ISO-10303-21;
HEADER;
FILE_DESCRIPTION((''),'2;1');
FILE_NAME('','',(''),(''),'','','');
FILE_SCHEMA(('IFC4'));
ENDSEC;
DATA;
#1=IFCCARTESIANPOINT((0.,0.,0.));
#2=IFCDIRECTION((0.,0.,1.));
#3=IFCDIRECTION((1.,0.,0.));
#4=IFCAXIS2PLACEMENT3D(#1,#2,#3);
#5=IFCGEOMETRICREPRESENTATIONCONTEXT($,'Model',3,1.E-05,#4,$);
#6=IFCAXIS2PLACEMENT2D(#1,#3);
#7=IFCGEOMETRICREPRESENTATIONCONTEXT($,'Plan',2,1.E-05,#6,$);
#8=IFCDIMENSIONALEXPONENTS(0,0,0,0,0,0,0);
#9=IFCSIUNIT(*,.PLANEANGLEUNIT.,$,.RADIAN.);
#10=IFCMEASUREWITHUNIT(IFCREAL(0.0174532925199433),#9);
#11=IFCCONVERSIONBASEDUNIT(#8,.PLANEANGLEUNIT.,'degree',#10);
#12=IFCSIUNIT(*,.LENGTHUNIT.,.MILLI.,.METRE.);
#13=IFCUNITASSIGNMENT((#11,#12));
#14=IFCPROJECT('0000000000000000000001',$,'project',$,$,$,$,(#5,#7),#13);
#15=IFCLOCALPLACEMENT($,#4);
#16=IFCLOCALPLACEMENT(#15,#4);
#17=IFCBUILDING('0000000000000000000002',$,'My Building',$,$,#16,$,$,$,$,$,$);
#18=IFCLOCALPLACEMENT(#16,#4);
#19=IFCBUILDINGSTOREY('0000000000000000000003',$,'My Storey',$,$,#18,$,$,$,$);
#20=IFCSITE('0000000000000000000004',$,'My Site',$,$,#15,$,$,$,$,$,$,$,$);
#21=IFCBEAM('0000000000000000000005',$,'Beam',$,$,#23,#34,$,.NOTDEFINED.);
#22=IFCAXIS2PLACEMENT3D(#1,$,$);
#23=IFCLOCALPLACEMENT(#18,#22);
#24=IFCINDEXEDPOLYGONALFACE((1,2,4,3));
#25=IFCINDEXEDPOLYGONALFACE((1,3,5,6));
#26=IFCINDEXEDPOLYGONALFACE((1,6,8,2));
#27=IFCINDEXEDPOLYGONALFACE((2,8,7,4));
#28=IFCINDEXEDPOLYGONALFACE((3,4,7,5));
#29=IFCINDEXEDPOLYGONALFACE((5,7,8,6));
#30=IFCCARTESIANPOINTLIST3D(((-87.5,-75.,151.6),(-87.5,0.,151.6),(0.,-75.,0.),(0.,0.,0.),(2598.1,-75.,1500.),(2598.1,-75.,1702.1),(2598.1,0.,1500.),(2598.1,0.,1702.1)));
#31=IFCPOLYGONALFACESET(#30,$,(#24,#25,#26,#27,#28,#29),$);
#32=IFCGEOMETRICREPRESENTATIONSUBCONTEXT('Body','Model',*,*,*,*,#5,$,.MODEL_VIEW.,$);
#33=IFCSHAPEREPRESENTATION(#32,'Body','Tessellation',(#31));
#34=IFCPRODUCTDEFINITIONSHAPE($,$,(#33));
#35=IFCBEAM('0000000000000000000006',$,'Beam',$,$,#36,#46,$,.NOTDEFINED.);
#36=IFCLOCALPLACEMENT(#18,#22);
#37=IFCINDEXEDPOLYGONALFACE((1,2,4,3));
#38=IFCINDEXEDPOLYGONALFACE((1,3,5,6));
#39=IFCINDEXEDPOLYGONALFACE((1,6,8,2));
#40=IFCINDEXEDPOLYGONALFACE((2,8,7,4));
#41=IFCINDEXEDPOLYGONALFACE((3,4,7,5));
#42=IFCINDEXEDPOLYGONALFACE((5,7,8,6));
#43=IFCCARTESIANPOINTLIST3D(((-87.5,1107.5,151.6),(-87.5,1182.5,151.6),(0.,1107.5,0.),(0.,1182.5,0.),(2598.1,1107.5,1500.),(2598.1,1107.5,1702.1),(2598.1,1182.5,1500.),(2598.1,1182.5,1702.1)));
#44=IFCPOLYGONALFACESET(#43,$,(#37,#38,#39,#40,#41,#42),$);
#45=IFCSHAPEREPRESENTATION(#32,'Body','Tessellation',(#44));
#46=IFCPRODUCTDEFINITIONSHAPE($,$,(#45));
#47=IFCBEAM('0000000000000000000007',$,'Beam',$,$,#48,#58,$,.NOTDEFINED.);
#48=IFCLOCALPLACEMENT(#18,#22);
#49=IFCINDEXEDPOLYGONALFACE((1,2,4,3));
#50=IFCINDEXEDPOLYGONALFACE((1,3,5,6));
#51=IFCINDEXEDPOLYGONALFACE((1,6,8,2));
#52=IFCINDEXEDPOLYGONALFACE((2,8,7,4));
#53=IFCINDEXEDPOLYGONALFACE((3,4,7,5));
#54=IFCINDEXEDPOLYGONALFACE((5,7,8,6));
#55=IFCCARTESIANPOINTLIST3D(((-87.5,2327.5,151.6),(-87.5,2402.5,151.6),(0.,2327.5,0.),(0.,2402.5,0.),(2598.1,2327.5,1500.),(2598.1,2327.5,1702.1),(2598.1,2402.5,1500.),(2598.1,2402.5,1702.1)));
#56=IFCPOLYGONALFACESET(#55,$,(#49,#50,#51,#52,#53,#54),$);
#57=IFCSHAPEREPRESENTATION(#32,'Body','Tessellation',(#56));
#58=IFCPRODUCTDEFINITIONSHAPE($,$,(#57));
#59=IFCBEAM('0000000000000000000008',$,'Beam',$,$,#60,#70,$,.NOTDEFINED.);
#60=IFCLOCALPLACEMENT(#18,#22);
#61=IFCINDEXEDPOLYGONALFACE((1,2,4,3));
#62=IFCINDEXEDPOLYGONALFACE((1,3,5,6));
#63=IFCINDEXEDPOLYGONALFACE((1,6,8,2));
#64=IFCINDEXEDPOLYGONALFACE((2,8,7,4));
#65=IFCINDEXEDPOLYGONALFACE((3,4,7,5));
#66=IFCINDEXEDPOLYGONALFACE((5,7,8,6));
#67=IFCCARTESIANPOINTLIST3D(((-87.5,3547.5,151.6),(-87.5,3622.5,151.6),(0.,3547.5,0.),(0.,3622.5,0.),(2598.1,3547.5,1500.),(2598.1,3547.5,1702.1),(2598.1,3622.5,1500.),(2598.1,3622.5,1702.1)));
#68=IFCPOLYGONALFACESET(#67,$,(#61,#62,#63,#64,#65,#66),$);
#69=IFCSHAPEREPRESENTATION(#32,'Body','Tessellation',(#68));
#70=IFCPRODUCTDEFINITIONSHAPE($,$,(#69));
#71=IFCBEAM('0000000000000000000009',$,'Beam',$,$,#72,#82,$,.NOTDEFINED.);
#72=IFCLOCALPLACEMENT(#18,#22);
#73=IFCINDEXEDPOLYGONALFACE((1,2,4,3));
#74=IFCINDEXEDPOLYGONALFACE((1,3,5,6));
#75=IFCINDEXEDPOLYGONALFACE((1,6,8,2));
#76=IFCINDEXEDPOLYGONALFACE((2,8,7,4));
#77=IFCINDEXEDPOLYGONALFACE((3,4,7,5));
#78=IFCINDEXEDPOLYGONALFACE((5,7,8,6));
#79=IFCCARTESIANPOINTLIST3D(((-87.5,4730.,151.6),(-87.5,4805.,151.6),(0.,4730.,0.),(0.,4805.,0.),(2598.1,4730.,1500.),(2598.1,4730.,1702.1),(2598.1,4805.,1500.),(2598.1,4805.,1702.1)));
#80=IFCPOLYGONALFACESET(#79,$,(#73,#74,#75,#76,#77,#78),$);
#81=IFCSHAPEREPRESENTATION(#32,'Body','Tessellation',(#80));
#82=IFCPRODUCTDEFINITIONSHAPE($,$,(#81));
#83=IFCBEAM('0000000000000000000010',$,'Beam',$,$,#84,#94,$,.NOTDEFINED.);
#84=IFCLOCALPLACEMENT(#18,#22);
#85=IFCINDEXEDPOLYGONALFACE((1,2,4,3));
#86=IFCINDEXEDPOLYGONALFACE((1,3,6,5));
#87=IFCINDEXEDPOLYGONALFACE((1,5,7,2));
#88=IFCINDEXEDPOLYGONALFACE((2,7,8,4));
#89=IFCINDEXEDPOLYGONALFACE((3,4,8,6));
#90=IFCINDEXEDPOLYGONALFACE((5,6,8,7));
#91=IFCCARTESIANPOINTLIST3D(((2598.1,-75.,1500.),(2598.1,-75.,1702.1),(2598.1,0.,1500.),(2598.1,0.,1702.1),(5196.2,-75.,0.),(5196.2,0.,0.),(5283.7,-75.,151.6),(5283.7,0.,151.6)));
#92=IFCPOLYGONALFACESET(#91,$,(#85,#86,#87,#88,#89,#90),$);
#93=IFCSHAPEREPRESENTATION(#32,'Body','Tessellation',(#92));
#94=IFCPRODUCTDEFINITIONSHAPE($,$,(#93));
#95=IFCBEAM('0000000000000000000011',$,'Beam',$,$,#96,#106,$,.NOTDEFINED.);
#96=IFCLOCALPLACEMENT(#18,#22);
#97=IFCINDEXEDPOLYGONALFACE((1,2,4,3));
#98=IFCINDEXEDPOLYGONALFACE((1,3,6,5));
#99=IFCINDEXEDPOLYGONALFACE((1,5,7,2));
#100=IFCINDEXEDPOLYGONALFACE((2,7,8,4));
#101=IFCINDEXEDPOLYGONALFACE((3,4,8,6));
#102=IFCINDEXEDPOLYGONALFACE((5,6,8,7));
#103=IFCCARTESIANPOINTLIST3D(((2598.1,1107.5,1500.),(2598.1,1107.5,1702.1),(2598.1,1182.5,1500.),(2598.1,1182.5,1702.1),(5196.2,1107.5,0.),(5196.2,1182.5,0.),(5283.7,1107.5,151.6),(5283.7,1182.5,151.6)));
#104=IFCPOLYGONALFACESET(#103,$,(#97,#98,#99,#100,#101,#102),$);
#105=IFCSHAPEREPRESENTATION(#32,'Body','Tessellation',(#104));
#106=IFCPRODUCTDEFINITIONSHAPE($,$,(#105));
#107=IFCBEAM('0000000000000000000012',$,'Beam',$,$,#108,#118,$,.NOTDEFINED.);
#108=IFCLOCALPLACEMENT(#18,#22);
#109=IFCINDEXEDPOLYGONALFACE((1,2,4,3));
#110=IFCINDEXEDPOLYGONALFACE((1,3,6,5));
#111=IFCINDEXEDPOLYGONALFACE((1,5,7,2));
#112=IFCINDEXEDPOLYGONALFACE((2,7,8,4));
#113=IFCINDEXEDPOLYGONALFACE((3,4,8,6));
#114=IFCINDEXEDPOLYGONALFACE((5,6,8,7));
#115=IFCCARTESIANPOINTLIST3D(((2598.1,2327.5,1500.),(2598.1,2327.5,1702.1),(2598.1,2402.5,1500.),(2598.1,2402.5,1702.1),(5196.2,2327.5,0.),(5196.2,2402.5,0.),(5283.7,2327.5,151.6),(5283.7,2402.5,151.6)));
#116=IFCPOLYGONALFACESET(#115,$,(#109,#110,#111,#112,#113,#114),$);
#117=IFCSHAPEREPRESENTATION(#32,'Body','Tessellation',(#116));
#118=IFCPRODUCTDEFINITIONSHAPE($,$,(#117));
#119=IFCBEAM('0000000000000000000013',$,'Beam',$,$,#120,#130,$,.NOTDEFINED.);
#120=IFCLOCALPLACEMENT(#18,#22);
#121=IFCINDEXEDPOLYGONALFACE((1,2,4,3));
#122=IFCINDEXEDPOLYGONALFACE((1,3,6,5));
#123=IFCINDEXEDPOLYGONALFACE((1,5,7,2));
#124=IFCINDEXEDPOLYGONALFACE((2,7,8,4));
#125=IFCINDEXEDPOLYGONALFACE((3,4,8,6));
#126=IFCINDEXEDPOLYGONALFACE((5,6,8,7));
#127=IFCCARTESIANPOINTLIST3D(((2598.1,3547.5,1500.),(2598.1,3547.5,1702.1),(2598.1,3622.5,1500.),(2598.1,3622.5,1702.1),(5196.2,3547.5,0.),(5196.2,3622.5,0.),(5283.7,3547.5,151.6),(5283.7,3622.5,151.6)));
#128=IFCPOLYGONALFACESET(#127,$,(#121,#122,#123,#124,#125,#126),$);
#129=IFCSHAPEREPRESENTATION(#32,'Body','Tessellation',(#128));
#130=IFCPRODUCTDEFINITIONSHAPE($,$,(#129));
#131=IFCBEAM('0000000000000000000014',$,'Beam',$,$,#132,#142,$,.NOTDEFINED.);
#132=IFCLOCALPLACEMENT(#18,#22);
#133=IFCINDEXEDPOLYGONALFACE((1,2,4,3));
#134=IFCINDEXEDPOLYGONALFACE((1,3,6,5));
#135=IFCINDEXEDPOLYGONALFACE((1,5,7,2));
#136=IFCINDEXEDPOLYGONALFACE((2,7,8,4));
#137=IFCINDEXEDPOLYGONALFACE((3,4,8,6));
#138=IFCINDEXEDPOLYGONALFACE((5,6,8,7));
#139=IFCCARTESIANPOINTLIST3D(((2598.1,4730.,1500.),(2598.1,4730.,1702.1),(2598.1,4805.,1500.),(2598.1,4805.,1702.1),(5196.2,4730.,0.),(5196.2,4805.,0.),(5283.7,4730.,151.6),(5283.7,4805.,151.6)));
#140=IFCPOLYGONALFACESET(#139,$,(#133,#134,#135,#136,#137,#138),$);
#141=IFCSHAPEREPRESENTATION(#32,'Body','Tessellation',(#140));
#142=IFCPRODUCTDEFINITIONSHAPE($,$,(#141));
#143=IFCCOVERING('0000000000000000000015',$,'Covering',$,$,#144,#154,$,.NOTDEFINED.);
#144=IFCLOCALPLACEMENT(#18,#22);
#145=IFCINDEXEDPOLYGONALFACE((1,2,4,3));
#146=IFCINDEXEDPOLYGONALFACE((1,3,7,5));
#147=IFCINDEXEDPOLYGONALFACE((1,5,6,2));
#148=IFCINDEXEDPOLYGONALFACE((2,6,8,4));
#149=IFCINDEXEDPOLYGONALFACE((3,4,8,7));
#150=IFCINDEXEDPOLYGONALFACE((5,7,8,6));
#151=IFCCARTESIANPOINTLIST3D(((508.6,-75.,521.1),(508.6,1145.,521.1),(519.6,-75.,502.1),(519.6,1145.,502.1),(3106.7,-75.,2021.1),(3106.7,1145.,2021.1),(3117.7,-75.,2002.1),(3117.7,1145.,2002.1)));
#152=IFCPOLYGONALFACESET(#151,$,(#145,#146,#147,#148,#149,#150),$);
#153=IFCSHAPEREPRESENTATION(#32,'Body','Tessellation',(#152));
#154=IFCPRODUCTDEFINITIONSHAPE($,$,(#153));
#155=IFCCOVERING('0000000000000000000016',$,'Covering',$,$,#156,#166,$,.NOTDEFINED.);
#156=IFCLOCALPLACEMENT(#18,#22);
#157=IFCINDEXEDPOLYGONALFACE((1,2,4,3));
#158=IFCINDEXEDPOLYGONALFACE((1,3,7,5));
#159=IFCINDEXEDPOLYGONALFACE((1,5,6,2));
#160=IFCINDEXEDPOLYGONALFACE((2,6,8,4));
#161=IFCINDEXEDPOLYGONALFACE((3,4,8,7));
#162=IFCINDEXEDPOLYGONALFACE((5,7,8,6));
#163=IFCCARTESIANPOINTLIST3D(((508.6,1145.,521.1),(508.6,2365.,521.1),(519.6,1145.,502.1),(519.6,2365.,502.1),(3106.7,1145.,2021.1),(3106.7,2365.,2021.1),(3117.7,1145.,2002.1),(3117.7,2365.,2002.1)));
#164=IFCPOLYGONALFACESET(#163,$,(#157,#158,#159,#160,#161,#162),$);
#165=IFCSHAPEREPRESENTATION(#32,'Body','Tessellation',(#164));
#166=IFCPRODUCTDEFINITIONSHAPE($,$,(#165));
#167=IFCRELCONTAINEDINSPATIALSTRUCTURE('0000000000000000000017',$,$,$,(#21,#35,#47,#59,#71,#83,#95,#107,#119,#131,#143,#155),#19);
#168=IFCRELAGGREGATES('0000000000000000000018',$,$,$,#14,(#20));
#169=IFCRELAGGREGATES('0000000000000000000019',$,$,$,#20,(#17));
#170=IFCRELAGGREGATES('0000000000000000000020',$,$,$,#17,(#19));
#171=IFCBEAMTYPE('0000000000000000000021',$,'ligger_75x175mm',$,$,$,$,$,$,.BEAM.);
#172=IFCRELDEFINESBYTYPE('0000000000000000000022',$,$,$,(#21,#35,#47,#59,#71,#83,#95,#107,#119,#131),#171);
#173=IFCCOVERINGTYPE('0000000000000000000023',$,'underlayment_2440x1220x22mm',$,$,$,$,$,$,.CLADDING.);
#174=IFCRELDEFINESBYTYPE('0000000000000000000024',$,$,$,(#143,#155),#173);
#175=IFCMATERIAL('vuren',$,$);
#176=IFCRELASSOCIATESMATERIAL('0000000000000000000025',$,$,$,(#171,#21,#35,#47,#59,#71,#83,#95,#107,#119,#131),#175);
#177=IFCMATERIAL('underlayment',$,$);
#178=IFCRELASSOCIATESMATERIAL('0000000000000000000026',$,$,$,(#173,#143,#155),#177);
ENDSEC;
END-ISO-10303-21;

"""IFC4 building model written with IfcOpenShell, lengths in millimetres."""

from ifc_helpers import new_model, entity, si_unit, converted_unit, frame, frame_2d, origin_with_axes, place, context, subcontext, project, spatial, rectangle, extrude, clip, halfspace, material, material_profile, profile_set, profile_usage, type_object, element, save


model = new_model("IFC4")

# Units and contexts
model_context = context("Model", 3, precision=1e-05, world=origin_with_axes())
plan_context = context("Plan", 2, precision=1e-05, world=frame_2d((0.0, 0.0, 0.0), x_axis=(1.0, 0.0, 0.0)))
body_context = subcontext(model_context, "Body", "Model", "MODEL_VIEW")
ifc_project = project(units=[converted_unit("PLANEANGLEUNIT", "degree", entity("IfcReal", 0.0174532925199433), si_unit("PLANEANGLEUNIT", "RADIAN"), dimensions=[0, 0, 0, 0, 0, 0, 0]), si_unit("LENGTHUNIT", "METRE", prefix="MILLI")], contexts=[model_context, plan_context])

# Site, building, storey
site_placement = place(None, origin_with_axes())
site = spatial("IfcSite", under=ifc_project, at=site_placement, Name="My Site")
building_placement = place(site_placement, origin_with_axes())
building = spatial("IfcBuilding", under=site, at=building_placement, Name="My Building")
storey_placement = place(building_placement, origin_with_axes())
storey = spatial("IfcBuildingStorey", under=building, at=storey_placement, Name="My Storey")

# Beams
ifc_material_1 = material(Name="vuren")
ifc_material_profile_1 = material_profile(ifc_material_1, rectangle(XDim=75.0, YDim=175.0))
ifc_profile_set_1 = profile_set([ifc_material_profile_1])
ifc_profile_usage_1 = profile_usage(ifc_profile_set_1, cardinal=1)
beam_type = type_object("IfcBeamType", Name="ligger_75x175mm", PredefinedType="BEAM", material=ifc_profile_set_1)
beam_1_placement = place(storey_placement, frame((0.0, 0.0, 0.0), z_axis=(0.866026, 0.0, 0.5), x_axis=(0.0, 1.0, 0.0)))
element("IfcBeam", 1, at=beam_1_placement, inside=storey, type_object=beam_type, material=ifc_profile_usage_1, Name="Beam", PredefinedType="NOTDEFINED", context=body_context, shape_type="Clipping", body=[
    clip(extrude(rectangle(XDim=75.0, YDim=175.0), frame((-37.5, 87.5, 0.0), z_axis=(0.0, 0.0, 1.0), x_axis=(1.0, 0.0, 0.0)), (0.0, 0.0, 1.0), 3377.1), halfspace(frame((0.0, 175.0, 3101.0), z_axis=(0.0, -0.500001, 0.866025), x_axis=(0.0, -0.866025, -0.500001)), False)),
])
ifc_profile_usage_2 = profile_usage(ifc_profile_set_1)
beam_2_placement = place(storey_placement, frame((-43.8, 1145.0, 75.8), z_axis=(0.866026, 0.0, 0.5), x_axis=(0.0, 1.0, 0.0)))
element("IfcBeam", 2, at=beam_2_placement, inside=storey, type_object=beam_type, material=ifc_profile_usage_2, Name="Beam", PredefinedType="NOTDEFINED", context=body_context, shape_type="Clipping", body=[
    clip(extrude(rectangle(XDim=75.0, YDim=175.0), origin_with_axes(), (0.0, 0.0, 1.0), 3326.6), halfspace(frame((-1000.0, 87.5, 3101.0), z_axis=(0.0, -0.499999, 0.866026), x_axis=(0.0, -0.866026, -0.499999)), False)),
])
ifc_profile_usage_3 = profile_usage(ifc_profile_set_1)
beam_3_placement = place(storey_placement, frame((-43.8, 2365.0, 75.8), z_axis=(0.866026, 0.0, 0.5), x_axis=(-0.000001, 1.0, 0.0)))
element("IfcBeam", 3, at=beam_3_placement, inside=storey, type_object=beam_type, material=ifc_profile_usage_3, Name="Beam", PredefinedType="NOTDEFINED", context=body_context, shape_type="Clipping", body=[
    clip(extrude(rectangle(XDim=75.0, YDim=175.0), origin_with_axes(), (0.0, 0.0, 1.0), 3326.6), halfspace(frame((-2000.0, 87.5, 3101.0), z_axis=(0.0, -0.499998, 0.866027), x_axis=(0.0, -0.866027, -0.499998)), False)),
])
ifc_profile_usage_4 = profile_usage(ifc_profile_set_1, cardinal=1)
beam_4_placement = place(storey_placement, frame((0.0, 3622.5, 0.0), z_axis=(0.866026, 0.0, 0.5), x_axis=(0.0, 1.0, 0.0)))
element("IfcBeam", 4, at=beam_4_placement, inside=storey, type_object=beam_type, material=ifc_profile_usage_4, Name="Beam", PredefinedType="NOTDEFINED", context=body_context, shape_type="Clipping", body=[
    clip(extrude(rectangle(XDim=75.0, YDim=175.0), frame((-37.5, 87.5, 0.0), z_axis=(0.0, 0.0, 1.0), x_axis=(1.0, 0.0, 0.0)), (0.0, 0.0, 1.0), 3377.1), halfspace(frame((-3000.0, 175.0, 3101.0), z_axis=(0.0, -0.499999, 0.866026), x_axis=(0.0, -0.866026, -0.499999)), False)),
])
ifc_profile_usage_5 = profile_usage(ifc_profile_set_1, cardinal=1)
beam_5_placement = place(storey_placement, frame((0.0, 4805.0, 0.0), z_axis=(0.866026, 0.0, 0.5), x_axis=(0.0, 1.0, 0.0)))
element("IfcBeam", 5, at=beam_5_placement, inside=storey, type_object=beam_type, material=ifc_profile_usage_5, Name="Beam", PredefinedType="NOTDEFINED", context=body_context, shape_type="Clipping", body=[
    clip(extrude(rectangle(XDim=75.0, YDim=175.0), frame((-37.5, 87.5, 0.0), z_axis=(0.0, 0.0, 1.0), x_axis=(1.0, 0.0, 0.0)), (0.0, 0.0, 1.0), 3377.1), halfspace(frame((-4000.0, 175.0, 3101.0), z_axis=(0.0, -0.500001, 0.866025), x_axis=(0.0, -0.866025, -0.500001)), False)),
])
ifc_profile_usage_6 = profile_usage(ifc_profile_set_1, cardinal=1)
beam_6_placement = place(storey_placement, frame((5196.2, -75.0, 0.0), z_axis=(-0.866026, 0.0, 0.5), x_axis=(0.0, -1.0, 0.0)))
element("IfcBeam", 6, at=beam_6_placement, inside=storey, type_object=beam_type, material=ifc_profile_usage_6, Name="Beam", PredefinedType="NOTDEFINED", context=body_context, shape_type="Clipping", body=[
    clip(extrude(rectangle(XDim=75.0, YDim=175.0), frame((-37.5, 87.5, 0.0), z_axis=(0.0, 0.0, 1.0), x_axis=(1.0, 0.0, 0.0)), (0.0, 0.0, 1.0), 3377.1), halfspace(frame((-75.0, 175.0, 3101.0), z_axis=(0.0, -0.499999, 0.866026), x_axis=(0.0, -0.866026, -0.499999)), False)),
])
ifc_profile_usage_7 = profile_usage(ifc_profile_set_1, cardinal=1)
beam_7_placement = place(storey_placement, frame((5196.2, 1107.5, 0.0), z_axis=(-0.866026, 0.0, 0.5), x_axis=(0.000001, -1.0, 0.0)))
element("IfcBeam", 7, at=beam_7_placement, inside=storey, type_object=beam_type, material=ifc_profile_usage_7, Name="Beam", PredefinedType="NOTDEFINED", context=body_context, shape_type="Clipping", body=[
    clip(extrude(rectangle(XDim=75.0, YDim=175.0), frame((-37.5, 87.5, 0.0), z_axis=(0.0, 0.0, 1.0), x_axis=(1.0, 0.0, 0.0)), (0.0, 0.0, 1.0), 3377.1), halfspace(frame((962.5, 175.0, 3101.0), z_axis=(0.0, -0.500001, 0.866025), x_axis=(0.0, -0.866025, -0.500001)), False)),
])
ifc_profile_usage_8 = profile_usage(ifc_profile_set_1)
beam_8_placement = place(storey_placement, frame((5239.9, 2365.0, 75.8), z_axis=(-0.866026, 0.0, 0.5), x_axis=(0.000001, -1.0, 0.0)))
element("IfcBeam", 8, at=beam_8_placement, inside=storey, type_object=beam_type, material=ifc_profile_usage_8, Name="Beam", PredefinedType="NOTDEFINED", context=body_context, shape_type="Clipping", body=[
    clip(extrude(rectangle(XDim=75.0, YDim=175.0), origin_with_axes(), (0.0, 0.0, 1.0), 3326.6), halfspace(frame((2000.0, 87.5, 3101.0), z_axis=(0.0, -0.500002, 0.866024), x_axis=(0.0, -0.866024, -0.500002)), False)),
])
ifc_profile_usage_9 = profile_usage(ifc_profile_set_1)
beam_9_placement = place(storey_placement, frame((5239.9, 3585.0, 75.8), z_axis=(-0.866026, 0.0, 0.5), x_axis=(0.000001, -1.0, 0.0)))
element("IfcBeam", 9, at=beam_9_placement, inside=storey, type_object=beam_type, material=ifc_profile_usage_9, Name="Beam", PredefinedType="NOTDEFINED", context=body_context, shape_type="Clipping", body=[
    clip(extrude(rectangle(XDim=75.0, YDim=175.0), origin_with_axes(), (0.0, 0.0, 1.0), 3326.6), halfspace(frame((2962.5, 87.5, 3101.0), z_axis=(0.0, -0.500001, 0.866025), x_axis=(0.0, -0.866025, -0.500001)), False)),
])
ifc_profile_usage_10 = profile_usage(ifc_profile_set_1, cardinal=1)
beam_10_placement = place(storey_placement, frame((5196.2, 4730.0, 0.0), z_axis=(-0.866026, 0.0, 0.5), x_axis=(0.000001, -1.0, 0.0)))
element("IfcBeam", 10, at=beam_10_placement, inside=storey, type_object=beam_type, material=ifc_profile_usage_10, Name="Beam", PredefinedType="NOTDEFINED", context=body_context, shape_type="Clipping", body=[
    clip(extrude(rectangle(XDim=75.0, YDim=175.0), frame((-37.5, 87.5, 0.0), z_axis=(0.0, 0.0, 1.0), x_axis=(1.0, 0.0, 0.0)), (0.0, 0.0, 1.0), 3377.1), halfspace(frame((3925.0, 175.0, 3101.0), z_axis=(0.0, -0.499999, 0.866026), x_axis=(0.0, -0.866026, -0.499999)), False)),
])

# Coverings
ifc_material_2 = material(Name="underlayment")
ifc_material_profile_2 = material_profile(ifc_material_2, rectangle(XDim=1220.0, YDim=22.0))
ifc_profile_set_2 = profile_set([ifc_material_profile_2])
ifc_profile_usage_11 = profile_usage(ifc_profile_set_2, cardinal=1)
covering_type = type_object("IfcCoveringType", Name="underlayment_2440x1220x22mm", PredefinedType="CLADDING", material=ifc_profile_set_2)
covering_1_placement = place(storey_placement, frame((519.6, 1145.0, 502.1), z_axis=(0.866026, 0.0, 0.5), x_axis=(0.0, 1.0, 0.0)))
element("IfcCovering", 11, at=covering_1_placement, inside=storey, type_object=covering_type, material=ifc_profile_usage_11, Name="Covering", PredefinedType="NOTDEFINED", context=body_context, shape_type="SweptSolid", body=[
    extrude(rectangle(XDim=1220.0, YDim=22.0), frame((-610.0, 11.0, 0.0), z_axis=(0.0, 0.0, 1.0), x_axis=(1.0, 0.0, 0.0)), (0.0, 0.0, 1.0), 3000.0),
])
ifc_profile_usage_12 = profile_usage(ifc_profile_set_2, cardinal=1)
covering_2_placement = place(storey_placement, frame((519.6, 2365.0, 502.1), z_axis=(0.866026, 0.0, 0.5), x_axis=(0.0, 1.0, 0.0)))
element("IfcCovering", 12, at=covering_2_placement, inside=storey, type_object=covering_type, material=ifc_profile_usage_12, Name="Covering", PredefinedType="NOTDEFINED", context=body_context, shape_type="SweptSolid", body=[
    extrude(rectangle(XDim=1220.0, YDim=22.0), frame((-610.0, 11.0, 0.0), z_axis=(0.0, 0.0, 1.0), x_axis=(1.0, 0.0, 0.0)), (0.0, 0.0, 1.0), 3000.0),
])

save(model, "model.ifc")
